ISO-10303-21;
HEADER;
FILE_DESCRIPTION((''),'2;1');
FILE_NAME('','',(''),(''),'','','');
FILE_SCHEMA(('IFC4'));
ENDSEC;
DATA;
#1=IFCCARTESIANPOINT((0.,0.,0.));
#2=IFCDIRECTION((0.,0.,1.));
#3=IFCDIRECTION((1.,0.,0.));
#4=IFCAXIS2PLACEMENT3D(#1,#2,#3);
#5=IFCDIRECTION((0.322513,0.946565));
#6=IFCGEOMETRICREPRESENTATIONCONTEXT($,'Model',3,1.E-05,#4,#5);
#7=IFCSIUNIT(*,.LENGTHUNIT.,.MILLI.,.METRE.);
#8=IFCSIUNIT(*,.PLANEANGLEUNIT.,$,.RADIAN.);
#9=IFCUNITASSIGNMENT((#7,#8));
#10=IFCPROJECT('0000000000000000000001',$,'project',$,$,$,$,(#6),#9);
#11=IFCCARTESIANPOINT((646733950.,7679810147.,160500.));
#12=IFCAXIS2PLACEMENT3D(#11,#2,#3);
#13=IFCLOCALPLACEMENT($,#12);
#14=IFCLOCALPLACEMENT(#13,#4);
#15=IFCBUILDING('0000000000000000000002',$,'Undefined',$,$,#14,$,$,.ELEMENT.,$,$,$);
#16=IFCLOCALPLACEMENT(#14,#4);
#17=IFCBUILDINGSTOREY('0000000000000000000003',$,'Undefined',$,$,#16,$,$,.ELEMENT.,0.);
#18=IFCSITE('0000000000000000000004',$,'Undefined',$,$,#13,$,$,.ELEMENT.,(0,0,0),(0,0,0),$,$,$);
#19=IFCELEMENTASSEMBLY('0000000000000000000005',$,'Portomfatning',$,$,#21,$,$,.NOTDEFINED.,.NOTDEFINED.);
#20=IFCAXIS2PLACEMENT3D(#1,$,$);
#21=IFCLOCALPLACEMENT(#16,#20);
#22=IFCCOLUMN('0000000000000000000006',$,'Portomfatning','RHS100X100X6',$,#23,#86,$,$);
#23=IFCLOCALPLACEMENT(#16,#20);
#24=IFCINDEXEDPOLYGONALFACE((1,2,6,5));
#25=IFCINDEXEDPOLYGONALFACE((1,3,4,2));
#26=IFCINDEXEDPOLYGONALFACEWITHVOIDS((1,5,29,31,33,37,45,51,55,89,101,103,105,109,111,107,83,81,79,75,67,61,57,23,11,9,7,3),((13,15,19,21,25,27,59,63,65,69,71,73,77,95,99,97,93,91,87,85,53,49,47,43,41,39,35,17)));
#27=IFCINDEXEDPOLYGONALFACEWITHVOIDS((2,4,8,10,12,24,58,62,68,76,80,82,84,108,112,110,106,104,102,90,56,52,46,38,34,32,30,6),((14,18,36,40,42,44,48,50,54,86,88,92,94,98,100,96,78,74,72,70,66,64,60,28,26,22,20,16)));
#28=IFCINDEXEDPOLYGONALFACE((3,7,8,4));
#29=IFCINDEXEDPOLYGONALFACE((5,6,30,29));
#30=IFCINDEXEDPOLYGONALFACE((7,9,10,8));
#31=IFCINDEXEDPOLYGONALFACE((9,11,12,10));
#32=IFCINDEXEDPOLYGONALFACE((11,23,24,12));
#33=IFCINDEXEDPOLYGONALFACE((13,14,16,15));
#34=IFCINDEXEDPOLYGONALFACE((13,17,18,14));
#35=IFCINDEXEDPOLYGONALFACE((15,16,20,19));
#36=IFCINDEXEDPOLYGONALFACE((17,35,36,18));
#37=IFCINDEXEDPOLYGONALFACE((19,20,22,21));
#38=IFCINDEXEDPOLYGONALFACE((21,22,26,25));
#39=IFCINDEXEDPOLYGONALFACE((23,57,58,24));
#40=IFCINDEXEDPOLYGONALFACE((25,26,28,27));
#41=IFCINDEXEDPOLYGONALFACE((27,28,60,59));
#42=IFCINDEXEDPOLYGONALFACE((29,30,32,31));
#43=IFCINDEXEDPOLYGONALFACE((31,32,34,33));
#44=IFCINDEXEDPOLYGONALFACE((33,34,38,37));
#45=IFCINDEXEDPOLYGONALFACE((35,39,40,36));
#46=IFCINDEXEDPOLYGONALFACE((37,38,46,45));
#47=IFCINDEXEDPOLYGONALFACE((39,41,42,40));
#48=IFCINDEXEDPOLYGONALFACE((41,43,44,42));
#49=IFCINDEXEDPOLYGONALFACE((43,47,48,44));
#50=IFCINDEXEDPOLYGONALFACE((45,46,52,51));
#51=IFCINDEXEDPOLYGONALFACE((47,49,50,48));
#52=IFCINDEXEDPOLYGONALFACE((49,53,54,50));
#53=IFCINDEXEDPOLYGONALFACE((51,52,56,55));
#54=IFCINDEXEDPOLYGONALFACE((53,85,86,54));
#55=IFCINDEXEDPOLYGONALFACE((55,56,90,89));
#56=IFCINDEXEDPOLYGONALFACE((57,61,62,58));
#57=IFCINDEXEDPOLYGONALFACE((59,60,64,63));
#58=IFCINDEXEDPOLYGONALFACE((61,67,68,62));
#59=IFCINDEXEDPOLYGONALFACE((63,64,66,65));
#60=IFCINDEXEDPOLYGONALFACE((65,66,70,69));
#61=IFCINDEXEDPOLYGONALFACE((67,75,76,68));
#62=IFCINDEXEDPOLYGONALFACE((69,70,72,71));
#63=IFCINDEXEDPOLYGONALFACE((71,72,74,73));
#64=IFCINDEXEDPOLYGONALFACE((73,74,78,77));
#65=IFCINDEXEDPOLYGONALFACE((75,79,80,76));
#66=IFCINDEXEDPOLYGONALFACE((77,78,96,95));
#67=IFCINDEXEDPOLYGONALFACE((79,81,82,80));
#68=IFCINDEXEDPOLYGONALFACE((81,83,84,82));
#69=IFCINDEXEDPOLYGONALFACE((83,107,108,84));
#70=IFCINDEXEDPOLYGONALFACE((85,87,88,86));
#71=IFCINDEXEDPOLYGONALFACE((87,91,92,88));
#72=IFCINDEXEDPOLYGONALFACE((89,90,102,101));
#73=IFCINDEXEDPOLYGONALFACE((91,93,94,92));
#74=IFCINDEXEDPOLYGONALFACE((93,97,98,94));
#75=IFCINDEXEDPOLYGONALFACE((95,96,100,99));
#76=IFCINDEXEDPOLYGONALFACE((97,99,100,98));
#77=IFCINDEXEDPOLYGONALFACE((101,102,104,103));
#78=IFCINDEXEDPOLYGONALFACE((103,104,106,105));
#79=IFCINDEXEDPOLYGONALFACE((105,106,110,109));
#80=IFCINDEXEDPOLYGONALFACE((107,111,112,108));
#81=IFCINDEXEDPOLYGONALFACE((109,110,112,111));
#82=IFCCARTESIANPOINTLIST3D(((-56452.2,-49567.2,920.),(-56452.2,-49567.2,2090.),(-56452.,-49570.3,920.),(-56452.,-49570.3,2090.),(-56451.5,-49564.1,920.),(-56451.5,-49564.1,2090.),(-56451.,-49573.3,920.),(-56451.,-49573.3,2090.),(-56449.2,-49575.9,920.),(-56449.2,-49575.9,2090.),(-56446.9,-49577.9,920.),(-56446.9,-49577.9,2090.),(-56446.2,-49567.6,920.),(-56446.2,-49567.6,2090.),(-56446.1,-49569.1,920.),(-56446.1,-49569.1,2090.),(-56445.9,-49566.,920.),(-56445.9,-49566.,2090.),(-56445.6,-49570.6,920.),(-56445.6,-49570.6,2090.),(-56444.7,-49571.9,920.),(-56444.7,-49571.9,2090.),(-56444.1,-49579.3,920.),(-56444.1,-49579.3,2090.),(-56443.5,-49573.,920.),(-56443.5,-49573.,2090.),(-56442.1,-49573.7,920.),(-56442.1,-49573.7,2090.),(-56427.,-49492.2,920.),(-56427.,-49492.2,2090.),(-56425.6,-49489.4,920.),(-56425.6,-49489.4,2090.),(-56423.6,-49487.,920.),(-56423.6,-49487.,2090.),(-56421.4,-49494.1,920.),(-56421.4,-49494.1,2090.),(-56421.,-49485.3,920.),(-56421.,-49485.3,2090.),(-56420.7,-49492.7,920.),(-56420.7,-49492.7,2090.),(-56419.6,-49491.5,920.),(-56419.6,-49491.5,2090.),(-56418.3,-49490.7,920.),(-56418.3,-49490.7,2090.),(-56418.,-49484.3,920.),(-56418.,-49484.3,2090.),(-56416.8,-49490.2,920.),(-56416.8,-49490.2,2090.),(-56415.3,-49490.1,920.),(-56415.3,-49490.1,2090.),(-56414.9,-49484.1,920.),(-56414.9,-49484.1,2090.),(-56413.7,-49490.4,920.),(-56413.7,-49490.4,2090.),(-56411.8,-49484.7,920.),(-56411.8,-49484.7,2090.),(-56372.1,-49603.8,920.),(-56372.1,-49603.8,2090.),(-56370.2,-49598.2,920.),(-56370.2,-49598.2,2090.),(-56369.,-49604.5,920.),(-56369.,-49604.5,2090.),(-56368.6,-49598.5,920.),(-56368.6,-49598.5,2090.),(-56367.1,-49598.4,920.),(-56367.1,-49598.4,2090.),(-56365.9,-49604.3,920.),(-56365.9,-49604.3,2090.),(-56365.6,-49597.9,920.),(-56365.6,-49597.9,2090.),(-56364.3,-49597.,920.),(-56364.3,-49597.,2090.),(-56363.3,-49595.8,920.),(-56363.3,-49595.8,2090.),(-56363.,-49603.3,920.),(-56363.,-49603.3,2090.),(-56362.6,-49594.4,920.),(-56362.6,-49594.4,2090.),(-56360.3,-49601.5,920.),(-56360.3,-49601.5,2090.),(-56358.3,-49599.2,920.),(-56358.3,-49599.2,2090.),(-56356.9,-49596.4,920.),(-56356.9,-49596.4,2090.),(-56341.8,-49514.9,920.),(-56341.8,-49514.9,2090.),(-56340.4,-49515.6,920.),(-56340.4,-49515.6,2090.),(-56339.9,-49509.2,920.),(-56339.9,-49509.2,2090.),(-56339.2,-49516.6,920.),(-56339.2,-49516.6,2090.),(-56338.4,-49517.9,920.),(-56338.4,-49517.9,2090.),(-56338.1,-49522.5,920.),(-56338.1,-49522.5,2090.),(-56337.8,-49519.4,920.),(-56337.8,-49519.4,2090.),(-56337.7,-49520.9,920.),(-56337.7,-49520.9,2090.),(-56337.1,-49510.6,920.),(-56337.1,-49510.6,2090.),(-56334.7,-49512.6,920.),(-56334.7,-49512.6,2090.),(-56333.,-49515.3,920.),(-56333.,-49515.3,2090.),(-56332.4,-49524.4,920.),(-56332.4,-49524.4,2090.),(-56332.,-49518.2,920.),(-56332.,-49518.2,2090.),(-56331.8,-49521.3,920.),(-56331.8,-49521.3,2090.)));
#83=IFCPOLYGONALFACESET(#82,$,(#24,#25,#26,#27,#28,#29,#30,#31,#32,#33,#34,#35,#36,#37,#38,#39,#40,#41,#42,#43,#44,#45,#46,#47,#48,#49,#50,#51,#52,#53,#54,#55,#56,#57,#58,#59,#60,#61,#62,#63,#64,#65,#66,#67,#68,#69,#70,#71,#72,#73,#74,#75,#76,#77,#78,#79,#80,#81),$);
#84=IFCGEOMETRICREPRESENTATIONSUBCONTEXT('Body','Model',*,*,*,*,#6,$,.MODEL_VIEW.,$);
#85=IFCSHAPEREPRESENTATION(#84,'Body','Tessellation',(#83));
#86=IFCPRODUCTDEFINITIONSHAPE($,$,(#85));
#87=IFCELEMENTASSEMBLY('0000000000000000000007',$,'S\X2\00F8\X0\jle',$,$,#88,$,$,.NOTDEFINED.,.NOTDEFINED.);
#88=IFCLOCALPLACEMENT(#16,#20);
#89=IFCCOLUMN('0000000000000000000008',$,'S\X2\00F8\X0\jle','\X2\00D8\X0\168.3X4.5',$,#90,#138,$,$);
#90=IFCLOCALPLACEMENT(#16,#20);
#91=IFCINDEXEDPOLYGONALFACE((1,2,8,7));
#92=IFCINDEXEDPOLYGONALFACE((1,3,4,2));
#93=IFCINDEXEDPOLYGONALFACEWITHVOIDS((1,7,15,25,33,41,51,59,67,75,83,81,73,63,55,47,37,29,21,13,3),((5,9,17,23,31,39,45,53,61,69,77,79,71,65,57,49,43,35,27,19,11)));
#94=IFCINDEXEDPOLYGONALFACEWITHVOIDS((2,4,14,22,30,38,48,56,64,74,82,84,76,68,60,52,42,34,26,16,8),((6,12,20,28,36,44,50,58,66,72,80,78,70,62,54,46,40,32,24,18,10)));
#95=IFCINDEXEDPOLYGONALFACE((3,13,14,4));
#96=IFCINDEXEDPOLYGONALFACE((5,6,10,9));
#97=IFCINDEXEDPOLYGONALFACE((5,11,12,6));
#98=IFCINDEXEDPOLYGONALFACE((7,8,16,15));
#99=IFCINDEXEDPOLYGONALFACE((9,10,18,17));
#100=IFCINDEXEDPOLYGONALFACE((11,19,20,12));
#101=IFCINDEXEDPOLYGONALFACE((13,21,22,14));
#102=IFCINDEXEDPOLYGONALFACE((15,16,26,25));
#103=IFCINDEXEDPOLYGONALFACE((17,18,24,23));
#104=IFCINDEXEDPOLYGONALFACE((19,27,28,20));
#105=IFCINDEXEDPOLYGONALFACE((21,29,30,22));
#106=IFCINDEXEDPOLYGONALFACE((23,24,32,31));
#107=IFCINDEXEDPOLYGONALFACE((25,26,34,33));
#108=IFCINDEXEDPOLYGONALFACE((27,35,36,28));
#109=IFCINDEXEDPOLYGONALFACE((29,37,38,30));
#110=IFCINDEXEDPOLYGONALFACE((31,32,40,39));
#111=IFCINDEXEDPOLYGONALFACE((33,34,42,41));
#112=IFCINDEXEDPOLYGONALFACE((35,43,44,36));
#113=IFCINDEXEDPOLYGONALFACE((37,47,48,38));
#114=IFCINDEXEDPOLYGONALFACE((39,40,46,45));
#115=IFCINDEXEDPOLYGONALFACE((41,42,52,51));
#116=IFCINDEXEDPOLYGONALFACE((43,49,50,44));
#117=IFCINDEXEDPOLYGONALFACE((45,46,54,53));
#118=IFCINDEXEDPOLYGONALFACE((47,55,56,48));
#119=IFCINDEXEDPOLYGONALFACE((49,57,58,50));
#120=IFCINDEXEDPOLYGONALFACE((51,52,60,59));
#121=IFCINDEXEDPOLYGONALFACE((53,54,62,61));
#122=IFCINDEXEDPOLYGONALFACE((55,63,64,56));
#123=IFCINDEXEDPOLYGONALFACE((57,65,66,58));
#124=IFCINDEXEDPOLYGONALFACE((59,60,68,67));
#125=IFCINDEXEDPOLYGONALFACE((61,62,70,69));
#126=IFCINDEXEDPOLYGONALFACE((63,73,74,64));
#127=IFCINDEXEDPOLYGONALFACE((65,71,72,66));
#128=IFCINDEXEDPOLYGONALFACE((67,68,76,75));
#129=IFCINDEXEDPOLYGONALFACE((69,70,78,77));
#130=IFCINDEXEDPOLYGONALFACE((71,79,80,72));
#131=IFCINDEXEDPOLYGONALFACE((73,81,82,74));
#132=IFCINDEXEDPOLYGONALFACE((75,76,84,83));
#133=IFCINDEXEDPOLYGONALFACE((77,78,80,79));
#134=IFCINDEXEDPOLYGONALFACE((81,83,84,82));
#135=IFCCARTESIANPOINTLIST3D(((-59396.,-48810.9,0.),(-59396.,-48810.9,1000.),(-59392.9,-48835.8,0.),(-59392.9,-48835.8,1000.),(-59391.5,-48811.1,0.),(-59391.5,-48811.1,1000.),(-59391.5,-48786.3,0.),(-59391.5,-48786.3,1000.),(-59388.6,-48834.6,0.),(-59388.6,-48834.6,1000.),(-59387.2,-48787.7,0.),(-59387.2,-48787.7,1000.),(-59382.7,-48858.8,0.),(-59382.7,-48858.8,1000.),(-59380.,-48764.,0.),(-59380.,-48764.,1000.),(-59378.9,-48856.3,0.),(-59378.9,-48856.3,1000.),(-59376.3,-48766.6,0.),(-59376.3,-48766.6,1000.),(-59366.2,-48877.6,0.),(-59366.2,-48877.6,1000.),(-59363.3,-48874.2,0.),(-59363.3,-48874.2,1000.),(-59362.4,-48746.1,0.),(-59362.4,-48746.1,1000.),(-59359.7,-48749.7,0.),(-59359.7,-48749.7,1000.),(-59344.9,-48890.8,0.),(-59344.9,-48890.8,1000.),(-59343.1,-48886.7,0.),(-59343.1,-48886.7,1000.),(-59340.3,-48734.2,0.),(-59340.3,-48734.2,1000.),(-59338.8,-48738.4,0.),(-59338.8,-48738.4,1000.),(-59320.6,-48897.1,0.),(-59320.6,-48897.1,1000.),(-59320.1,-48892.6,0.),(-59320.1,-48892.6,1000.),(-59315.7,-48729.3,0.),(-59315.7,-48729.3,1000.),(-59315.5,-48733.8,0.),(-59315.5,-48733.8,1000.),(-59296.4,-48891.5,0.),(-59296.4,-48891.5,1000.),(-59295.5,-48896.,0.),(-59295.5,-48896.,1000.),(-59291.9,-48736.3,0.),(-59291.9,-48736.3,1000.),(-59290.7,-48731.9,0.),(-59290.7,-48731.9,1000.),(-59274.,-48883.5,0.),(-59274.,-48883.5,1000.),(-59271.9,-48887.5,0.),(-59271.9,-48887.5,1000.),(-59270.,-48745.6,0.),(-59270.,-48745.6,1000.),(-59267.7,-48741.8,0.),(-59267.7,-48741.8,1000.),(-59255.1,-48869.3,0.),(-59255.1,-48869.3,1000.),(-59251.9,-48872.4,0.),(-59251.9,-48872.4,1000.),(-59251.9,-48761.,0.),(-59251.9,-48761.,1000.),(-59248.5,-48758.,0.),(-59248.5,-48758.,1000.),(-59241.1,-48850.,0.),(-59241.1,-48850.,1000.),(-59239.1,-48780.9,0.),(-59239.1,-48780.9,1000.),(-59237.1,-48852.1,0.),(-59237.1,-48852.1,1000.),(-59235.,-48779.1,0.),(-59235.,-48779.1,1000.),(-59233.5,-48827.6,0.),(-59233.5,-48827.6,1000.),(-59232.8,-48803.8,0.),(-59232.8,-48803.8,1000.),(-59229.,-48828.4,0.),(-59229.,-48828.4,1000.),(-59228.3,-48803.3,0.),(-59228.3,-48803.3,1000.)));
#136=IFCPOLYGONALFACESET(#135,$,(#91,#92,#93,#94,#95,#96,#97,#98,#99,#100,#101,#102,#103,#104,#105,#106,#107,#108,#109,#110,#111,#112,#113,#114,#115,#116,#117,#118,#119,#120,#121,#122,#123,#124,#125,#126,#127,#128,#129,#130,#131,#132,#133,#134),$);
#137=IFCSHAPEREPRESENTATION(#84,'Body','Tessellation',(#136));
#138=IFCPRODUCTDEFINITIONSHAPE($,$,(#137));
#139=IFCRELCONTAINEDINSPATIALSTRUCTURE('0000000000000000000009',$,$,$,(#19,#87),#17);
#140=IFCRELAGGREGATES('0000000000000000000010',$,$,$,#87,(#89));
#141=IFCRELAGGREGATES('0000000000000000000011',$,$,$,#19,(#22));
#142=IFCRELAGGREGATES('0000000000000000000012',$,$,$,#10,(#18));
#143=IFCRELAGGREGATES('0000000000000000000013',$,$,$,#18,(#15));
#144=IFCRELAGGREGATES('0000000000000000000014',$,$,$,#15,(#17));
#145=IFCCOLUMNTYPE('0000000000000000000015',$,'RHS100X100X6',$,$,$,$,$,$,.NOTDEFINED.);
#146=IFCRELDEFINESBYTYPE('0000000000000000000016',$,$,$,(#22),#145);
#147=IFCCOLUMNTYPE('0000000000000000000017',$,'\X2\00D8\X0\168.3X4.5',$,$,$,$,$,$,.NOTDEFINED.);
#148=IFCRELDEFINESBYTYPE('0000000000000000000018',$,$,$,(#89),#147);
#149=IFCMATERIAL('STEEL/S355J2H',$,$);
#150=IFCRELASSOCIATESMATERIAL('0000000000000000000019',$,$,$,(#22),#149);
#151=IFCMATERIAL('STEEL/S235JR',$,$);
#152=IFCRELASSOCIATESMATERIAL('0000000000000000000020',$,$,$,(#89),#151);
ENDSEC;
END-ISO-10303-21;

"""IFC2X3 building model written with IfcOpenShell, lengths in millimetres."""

from ifc_helpers import new_model, si_unit, direction, frame, origin_with_axes, origin_2d_with_axis, place, context, subcontext, project, spatial, hollow_rectangle, hollow_circle, extrude, clip, halfspace, material, type_object, element, aggregate, save


model = new_model("IFC2X3")

# Units and contexts
model_context = context("Model", 3, precision=1e-05, world=origin_with_axes(), true_north=direction((0.322513, 0.946565)))
body_context = subcontext(model_context, "Body", "Model", "MODEL_VIEW")
ifc_project = project(units=[si_unit("LENGTHUNIT", "METRE", prefix="MILLI"), si_unit("PLANEANGLEUNIT", "RADIAN")], contexts=[model_context])

# Site, building, storey
site_placement = place(None, frame((646733950.0, 7679810147.0, 160500.0), z_axis=(0.0, 0.0, 1.0), x_axis=(1.0, 0.0, 0.0)))
site = spatial("IfcSite", under=ifc_project, at=site_placement, Name="Undefined", CompositionType="ELEMENT", RefLatitude=(0, 0, 0), RefLongitude=(0, 0, 0))
building_placement = place(site_placement, origin_with_axes())
building = spatial("IfcBuilding", under=site, at=building_placement, Name="Undefined", CompositionType="ELEMENT")
storey_placement = place(building_placement, origin_with_axes())
storey = spatial("IfcBuildingStorey", under=building, at=storey_placement, Name="Undefined", CompositionType="ELEMENT", Elevation=0.0)

# Element assemblies, columns
ifc_material_1 = material(Name="STEEL/S355J2H")
column_type_1 = type_object("IfcColumnType", Name="RHS100X100X6", PredefinedType="NOTDEFINED")
assembly_1_placement = place(storey_placement, origin_with_axes())
assembly_1 = element("IfcElementAssembly", 1, at=assembly_1_placement, inside=storey, Name="Portomfatning", AssemblyPlace="NOTDEFINED", PredefinedType="NOTDEFINED")
column_1_placement = place(assembly_1_placement, frame((-56392.0, -49544.3, 910.0), z_axis=(0.0, 0.0, 1.0), x_axis=(-0.946565, 0.322513, 0.0)))
column_1 = element("IfcColumn", 2, at=column_1_placement, type_object=column_type_1, material=ifc_material_1, Name="Portomfatning", Description="RHS100X100X6", context=body_context, shape_type="Clipping", body=[
    clip(clip(extrude(hollow_rectangle(XDim=100.0, YDim=100.0, WallThickness=6.0, InnerFilletRadius=6.0, OuterFilletRadius=12.0, at=origin_2d_with_axis()), frame((0.0, 0.0, 1190.0), z_axis=(0.0, 0.0, -1.0), x_axis=(0.0, 1.0, 0.0)), (0.0, 0.0, 1.0), 1190.0), halfspace(frame((-50.0, 0.0, 1180.0), z_axis=(0.0, 0.0, -1.0), x_axis=(0.0, -1.0, 0.0)), True)), halfspace(frame((-50.0, 0.0, 10.0), z_axis=(0.0, 0.0, 1.0), x_axis=(0.0, 1.0, 0.0)), True)),
])
assembly_2_placement = place(storey_placement, origin_with_axes())
assembly_2 = element("IfcElementAssembly", 3, at=assembly_2_placement, inside=storey, Name="Søjle", AssemblyPlace="NOTDEFINED", PredefinedType="NOTDEFINED")
ifc_material_2 = material(Name="STEEL/S235JR")
column_type_2 = type_object("IfcColumnType", Name="Ø168.3X4.5", PredefinedType="NOTDEFINED")
column_2_placement = place(assembly_2_placement, frame((-59311.8, -48813.4, 0.0), z_axis=(0.0, 0.0, 1.0), x_axis=(0.322513, 0.946565, 0.0)))
column_2 = element("IfcColumn", 4, at=column_2_placement, type_object=column_type_2, material=ifc_material_2, Name="Søjle", Description="Ø168.3X4.5", context=body_context, shape_type="SweptSolid", body=[
    extrude(hollow_circle(Radius=84.2, WallThickness=4.5, at=origin_2d_with_axis()), frame((0.0, 0.0, 1000.0), z_axis=(0.0, 0.0, -1.0), x_axis=(0.0, 1.0, 0.0)), (0.0, 0.0, 1.0), 1000.0),
])
aggregate(assembly_2, [column_2])

aggregate(assembly_1, [column_1])

save(model, "model.ifc")
